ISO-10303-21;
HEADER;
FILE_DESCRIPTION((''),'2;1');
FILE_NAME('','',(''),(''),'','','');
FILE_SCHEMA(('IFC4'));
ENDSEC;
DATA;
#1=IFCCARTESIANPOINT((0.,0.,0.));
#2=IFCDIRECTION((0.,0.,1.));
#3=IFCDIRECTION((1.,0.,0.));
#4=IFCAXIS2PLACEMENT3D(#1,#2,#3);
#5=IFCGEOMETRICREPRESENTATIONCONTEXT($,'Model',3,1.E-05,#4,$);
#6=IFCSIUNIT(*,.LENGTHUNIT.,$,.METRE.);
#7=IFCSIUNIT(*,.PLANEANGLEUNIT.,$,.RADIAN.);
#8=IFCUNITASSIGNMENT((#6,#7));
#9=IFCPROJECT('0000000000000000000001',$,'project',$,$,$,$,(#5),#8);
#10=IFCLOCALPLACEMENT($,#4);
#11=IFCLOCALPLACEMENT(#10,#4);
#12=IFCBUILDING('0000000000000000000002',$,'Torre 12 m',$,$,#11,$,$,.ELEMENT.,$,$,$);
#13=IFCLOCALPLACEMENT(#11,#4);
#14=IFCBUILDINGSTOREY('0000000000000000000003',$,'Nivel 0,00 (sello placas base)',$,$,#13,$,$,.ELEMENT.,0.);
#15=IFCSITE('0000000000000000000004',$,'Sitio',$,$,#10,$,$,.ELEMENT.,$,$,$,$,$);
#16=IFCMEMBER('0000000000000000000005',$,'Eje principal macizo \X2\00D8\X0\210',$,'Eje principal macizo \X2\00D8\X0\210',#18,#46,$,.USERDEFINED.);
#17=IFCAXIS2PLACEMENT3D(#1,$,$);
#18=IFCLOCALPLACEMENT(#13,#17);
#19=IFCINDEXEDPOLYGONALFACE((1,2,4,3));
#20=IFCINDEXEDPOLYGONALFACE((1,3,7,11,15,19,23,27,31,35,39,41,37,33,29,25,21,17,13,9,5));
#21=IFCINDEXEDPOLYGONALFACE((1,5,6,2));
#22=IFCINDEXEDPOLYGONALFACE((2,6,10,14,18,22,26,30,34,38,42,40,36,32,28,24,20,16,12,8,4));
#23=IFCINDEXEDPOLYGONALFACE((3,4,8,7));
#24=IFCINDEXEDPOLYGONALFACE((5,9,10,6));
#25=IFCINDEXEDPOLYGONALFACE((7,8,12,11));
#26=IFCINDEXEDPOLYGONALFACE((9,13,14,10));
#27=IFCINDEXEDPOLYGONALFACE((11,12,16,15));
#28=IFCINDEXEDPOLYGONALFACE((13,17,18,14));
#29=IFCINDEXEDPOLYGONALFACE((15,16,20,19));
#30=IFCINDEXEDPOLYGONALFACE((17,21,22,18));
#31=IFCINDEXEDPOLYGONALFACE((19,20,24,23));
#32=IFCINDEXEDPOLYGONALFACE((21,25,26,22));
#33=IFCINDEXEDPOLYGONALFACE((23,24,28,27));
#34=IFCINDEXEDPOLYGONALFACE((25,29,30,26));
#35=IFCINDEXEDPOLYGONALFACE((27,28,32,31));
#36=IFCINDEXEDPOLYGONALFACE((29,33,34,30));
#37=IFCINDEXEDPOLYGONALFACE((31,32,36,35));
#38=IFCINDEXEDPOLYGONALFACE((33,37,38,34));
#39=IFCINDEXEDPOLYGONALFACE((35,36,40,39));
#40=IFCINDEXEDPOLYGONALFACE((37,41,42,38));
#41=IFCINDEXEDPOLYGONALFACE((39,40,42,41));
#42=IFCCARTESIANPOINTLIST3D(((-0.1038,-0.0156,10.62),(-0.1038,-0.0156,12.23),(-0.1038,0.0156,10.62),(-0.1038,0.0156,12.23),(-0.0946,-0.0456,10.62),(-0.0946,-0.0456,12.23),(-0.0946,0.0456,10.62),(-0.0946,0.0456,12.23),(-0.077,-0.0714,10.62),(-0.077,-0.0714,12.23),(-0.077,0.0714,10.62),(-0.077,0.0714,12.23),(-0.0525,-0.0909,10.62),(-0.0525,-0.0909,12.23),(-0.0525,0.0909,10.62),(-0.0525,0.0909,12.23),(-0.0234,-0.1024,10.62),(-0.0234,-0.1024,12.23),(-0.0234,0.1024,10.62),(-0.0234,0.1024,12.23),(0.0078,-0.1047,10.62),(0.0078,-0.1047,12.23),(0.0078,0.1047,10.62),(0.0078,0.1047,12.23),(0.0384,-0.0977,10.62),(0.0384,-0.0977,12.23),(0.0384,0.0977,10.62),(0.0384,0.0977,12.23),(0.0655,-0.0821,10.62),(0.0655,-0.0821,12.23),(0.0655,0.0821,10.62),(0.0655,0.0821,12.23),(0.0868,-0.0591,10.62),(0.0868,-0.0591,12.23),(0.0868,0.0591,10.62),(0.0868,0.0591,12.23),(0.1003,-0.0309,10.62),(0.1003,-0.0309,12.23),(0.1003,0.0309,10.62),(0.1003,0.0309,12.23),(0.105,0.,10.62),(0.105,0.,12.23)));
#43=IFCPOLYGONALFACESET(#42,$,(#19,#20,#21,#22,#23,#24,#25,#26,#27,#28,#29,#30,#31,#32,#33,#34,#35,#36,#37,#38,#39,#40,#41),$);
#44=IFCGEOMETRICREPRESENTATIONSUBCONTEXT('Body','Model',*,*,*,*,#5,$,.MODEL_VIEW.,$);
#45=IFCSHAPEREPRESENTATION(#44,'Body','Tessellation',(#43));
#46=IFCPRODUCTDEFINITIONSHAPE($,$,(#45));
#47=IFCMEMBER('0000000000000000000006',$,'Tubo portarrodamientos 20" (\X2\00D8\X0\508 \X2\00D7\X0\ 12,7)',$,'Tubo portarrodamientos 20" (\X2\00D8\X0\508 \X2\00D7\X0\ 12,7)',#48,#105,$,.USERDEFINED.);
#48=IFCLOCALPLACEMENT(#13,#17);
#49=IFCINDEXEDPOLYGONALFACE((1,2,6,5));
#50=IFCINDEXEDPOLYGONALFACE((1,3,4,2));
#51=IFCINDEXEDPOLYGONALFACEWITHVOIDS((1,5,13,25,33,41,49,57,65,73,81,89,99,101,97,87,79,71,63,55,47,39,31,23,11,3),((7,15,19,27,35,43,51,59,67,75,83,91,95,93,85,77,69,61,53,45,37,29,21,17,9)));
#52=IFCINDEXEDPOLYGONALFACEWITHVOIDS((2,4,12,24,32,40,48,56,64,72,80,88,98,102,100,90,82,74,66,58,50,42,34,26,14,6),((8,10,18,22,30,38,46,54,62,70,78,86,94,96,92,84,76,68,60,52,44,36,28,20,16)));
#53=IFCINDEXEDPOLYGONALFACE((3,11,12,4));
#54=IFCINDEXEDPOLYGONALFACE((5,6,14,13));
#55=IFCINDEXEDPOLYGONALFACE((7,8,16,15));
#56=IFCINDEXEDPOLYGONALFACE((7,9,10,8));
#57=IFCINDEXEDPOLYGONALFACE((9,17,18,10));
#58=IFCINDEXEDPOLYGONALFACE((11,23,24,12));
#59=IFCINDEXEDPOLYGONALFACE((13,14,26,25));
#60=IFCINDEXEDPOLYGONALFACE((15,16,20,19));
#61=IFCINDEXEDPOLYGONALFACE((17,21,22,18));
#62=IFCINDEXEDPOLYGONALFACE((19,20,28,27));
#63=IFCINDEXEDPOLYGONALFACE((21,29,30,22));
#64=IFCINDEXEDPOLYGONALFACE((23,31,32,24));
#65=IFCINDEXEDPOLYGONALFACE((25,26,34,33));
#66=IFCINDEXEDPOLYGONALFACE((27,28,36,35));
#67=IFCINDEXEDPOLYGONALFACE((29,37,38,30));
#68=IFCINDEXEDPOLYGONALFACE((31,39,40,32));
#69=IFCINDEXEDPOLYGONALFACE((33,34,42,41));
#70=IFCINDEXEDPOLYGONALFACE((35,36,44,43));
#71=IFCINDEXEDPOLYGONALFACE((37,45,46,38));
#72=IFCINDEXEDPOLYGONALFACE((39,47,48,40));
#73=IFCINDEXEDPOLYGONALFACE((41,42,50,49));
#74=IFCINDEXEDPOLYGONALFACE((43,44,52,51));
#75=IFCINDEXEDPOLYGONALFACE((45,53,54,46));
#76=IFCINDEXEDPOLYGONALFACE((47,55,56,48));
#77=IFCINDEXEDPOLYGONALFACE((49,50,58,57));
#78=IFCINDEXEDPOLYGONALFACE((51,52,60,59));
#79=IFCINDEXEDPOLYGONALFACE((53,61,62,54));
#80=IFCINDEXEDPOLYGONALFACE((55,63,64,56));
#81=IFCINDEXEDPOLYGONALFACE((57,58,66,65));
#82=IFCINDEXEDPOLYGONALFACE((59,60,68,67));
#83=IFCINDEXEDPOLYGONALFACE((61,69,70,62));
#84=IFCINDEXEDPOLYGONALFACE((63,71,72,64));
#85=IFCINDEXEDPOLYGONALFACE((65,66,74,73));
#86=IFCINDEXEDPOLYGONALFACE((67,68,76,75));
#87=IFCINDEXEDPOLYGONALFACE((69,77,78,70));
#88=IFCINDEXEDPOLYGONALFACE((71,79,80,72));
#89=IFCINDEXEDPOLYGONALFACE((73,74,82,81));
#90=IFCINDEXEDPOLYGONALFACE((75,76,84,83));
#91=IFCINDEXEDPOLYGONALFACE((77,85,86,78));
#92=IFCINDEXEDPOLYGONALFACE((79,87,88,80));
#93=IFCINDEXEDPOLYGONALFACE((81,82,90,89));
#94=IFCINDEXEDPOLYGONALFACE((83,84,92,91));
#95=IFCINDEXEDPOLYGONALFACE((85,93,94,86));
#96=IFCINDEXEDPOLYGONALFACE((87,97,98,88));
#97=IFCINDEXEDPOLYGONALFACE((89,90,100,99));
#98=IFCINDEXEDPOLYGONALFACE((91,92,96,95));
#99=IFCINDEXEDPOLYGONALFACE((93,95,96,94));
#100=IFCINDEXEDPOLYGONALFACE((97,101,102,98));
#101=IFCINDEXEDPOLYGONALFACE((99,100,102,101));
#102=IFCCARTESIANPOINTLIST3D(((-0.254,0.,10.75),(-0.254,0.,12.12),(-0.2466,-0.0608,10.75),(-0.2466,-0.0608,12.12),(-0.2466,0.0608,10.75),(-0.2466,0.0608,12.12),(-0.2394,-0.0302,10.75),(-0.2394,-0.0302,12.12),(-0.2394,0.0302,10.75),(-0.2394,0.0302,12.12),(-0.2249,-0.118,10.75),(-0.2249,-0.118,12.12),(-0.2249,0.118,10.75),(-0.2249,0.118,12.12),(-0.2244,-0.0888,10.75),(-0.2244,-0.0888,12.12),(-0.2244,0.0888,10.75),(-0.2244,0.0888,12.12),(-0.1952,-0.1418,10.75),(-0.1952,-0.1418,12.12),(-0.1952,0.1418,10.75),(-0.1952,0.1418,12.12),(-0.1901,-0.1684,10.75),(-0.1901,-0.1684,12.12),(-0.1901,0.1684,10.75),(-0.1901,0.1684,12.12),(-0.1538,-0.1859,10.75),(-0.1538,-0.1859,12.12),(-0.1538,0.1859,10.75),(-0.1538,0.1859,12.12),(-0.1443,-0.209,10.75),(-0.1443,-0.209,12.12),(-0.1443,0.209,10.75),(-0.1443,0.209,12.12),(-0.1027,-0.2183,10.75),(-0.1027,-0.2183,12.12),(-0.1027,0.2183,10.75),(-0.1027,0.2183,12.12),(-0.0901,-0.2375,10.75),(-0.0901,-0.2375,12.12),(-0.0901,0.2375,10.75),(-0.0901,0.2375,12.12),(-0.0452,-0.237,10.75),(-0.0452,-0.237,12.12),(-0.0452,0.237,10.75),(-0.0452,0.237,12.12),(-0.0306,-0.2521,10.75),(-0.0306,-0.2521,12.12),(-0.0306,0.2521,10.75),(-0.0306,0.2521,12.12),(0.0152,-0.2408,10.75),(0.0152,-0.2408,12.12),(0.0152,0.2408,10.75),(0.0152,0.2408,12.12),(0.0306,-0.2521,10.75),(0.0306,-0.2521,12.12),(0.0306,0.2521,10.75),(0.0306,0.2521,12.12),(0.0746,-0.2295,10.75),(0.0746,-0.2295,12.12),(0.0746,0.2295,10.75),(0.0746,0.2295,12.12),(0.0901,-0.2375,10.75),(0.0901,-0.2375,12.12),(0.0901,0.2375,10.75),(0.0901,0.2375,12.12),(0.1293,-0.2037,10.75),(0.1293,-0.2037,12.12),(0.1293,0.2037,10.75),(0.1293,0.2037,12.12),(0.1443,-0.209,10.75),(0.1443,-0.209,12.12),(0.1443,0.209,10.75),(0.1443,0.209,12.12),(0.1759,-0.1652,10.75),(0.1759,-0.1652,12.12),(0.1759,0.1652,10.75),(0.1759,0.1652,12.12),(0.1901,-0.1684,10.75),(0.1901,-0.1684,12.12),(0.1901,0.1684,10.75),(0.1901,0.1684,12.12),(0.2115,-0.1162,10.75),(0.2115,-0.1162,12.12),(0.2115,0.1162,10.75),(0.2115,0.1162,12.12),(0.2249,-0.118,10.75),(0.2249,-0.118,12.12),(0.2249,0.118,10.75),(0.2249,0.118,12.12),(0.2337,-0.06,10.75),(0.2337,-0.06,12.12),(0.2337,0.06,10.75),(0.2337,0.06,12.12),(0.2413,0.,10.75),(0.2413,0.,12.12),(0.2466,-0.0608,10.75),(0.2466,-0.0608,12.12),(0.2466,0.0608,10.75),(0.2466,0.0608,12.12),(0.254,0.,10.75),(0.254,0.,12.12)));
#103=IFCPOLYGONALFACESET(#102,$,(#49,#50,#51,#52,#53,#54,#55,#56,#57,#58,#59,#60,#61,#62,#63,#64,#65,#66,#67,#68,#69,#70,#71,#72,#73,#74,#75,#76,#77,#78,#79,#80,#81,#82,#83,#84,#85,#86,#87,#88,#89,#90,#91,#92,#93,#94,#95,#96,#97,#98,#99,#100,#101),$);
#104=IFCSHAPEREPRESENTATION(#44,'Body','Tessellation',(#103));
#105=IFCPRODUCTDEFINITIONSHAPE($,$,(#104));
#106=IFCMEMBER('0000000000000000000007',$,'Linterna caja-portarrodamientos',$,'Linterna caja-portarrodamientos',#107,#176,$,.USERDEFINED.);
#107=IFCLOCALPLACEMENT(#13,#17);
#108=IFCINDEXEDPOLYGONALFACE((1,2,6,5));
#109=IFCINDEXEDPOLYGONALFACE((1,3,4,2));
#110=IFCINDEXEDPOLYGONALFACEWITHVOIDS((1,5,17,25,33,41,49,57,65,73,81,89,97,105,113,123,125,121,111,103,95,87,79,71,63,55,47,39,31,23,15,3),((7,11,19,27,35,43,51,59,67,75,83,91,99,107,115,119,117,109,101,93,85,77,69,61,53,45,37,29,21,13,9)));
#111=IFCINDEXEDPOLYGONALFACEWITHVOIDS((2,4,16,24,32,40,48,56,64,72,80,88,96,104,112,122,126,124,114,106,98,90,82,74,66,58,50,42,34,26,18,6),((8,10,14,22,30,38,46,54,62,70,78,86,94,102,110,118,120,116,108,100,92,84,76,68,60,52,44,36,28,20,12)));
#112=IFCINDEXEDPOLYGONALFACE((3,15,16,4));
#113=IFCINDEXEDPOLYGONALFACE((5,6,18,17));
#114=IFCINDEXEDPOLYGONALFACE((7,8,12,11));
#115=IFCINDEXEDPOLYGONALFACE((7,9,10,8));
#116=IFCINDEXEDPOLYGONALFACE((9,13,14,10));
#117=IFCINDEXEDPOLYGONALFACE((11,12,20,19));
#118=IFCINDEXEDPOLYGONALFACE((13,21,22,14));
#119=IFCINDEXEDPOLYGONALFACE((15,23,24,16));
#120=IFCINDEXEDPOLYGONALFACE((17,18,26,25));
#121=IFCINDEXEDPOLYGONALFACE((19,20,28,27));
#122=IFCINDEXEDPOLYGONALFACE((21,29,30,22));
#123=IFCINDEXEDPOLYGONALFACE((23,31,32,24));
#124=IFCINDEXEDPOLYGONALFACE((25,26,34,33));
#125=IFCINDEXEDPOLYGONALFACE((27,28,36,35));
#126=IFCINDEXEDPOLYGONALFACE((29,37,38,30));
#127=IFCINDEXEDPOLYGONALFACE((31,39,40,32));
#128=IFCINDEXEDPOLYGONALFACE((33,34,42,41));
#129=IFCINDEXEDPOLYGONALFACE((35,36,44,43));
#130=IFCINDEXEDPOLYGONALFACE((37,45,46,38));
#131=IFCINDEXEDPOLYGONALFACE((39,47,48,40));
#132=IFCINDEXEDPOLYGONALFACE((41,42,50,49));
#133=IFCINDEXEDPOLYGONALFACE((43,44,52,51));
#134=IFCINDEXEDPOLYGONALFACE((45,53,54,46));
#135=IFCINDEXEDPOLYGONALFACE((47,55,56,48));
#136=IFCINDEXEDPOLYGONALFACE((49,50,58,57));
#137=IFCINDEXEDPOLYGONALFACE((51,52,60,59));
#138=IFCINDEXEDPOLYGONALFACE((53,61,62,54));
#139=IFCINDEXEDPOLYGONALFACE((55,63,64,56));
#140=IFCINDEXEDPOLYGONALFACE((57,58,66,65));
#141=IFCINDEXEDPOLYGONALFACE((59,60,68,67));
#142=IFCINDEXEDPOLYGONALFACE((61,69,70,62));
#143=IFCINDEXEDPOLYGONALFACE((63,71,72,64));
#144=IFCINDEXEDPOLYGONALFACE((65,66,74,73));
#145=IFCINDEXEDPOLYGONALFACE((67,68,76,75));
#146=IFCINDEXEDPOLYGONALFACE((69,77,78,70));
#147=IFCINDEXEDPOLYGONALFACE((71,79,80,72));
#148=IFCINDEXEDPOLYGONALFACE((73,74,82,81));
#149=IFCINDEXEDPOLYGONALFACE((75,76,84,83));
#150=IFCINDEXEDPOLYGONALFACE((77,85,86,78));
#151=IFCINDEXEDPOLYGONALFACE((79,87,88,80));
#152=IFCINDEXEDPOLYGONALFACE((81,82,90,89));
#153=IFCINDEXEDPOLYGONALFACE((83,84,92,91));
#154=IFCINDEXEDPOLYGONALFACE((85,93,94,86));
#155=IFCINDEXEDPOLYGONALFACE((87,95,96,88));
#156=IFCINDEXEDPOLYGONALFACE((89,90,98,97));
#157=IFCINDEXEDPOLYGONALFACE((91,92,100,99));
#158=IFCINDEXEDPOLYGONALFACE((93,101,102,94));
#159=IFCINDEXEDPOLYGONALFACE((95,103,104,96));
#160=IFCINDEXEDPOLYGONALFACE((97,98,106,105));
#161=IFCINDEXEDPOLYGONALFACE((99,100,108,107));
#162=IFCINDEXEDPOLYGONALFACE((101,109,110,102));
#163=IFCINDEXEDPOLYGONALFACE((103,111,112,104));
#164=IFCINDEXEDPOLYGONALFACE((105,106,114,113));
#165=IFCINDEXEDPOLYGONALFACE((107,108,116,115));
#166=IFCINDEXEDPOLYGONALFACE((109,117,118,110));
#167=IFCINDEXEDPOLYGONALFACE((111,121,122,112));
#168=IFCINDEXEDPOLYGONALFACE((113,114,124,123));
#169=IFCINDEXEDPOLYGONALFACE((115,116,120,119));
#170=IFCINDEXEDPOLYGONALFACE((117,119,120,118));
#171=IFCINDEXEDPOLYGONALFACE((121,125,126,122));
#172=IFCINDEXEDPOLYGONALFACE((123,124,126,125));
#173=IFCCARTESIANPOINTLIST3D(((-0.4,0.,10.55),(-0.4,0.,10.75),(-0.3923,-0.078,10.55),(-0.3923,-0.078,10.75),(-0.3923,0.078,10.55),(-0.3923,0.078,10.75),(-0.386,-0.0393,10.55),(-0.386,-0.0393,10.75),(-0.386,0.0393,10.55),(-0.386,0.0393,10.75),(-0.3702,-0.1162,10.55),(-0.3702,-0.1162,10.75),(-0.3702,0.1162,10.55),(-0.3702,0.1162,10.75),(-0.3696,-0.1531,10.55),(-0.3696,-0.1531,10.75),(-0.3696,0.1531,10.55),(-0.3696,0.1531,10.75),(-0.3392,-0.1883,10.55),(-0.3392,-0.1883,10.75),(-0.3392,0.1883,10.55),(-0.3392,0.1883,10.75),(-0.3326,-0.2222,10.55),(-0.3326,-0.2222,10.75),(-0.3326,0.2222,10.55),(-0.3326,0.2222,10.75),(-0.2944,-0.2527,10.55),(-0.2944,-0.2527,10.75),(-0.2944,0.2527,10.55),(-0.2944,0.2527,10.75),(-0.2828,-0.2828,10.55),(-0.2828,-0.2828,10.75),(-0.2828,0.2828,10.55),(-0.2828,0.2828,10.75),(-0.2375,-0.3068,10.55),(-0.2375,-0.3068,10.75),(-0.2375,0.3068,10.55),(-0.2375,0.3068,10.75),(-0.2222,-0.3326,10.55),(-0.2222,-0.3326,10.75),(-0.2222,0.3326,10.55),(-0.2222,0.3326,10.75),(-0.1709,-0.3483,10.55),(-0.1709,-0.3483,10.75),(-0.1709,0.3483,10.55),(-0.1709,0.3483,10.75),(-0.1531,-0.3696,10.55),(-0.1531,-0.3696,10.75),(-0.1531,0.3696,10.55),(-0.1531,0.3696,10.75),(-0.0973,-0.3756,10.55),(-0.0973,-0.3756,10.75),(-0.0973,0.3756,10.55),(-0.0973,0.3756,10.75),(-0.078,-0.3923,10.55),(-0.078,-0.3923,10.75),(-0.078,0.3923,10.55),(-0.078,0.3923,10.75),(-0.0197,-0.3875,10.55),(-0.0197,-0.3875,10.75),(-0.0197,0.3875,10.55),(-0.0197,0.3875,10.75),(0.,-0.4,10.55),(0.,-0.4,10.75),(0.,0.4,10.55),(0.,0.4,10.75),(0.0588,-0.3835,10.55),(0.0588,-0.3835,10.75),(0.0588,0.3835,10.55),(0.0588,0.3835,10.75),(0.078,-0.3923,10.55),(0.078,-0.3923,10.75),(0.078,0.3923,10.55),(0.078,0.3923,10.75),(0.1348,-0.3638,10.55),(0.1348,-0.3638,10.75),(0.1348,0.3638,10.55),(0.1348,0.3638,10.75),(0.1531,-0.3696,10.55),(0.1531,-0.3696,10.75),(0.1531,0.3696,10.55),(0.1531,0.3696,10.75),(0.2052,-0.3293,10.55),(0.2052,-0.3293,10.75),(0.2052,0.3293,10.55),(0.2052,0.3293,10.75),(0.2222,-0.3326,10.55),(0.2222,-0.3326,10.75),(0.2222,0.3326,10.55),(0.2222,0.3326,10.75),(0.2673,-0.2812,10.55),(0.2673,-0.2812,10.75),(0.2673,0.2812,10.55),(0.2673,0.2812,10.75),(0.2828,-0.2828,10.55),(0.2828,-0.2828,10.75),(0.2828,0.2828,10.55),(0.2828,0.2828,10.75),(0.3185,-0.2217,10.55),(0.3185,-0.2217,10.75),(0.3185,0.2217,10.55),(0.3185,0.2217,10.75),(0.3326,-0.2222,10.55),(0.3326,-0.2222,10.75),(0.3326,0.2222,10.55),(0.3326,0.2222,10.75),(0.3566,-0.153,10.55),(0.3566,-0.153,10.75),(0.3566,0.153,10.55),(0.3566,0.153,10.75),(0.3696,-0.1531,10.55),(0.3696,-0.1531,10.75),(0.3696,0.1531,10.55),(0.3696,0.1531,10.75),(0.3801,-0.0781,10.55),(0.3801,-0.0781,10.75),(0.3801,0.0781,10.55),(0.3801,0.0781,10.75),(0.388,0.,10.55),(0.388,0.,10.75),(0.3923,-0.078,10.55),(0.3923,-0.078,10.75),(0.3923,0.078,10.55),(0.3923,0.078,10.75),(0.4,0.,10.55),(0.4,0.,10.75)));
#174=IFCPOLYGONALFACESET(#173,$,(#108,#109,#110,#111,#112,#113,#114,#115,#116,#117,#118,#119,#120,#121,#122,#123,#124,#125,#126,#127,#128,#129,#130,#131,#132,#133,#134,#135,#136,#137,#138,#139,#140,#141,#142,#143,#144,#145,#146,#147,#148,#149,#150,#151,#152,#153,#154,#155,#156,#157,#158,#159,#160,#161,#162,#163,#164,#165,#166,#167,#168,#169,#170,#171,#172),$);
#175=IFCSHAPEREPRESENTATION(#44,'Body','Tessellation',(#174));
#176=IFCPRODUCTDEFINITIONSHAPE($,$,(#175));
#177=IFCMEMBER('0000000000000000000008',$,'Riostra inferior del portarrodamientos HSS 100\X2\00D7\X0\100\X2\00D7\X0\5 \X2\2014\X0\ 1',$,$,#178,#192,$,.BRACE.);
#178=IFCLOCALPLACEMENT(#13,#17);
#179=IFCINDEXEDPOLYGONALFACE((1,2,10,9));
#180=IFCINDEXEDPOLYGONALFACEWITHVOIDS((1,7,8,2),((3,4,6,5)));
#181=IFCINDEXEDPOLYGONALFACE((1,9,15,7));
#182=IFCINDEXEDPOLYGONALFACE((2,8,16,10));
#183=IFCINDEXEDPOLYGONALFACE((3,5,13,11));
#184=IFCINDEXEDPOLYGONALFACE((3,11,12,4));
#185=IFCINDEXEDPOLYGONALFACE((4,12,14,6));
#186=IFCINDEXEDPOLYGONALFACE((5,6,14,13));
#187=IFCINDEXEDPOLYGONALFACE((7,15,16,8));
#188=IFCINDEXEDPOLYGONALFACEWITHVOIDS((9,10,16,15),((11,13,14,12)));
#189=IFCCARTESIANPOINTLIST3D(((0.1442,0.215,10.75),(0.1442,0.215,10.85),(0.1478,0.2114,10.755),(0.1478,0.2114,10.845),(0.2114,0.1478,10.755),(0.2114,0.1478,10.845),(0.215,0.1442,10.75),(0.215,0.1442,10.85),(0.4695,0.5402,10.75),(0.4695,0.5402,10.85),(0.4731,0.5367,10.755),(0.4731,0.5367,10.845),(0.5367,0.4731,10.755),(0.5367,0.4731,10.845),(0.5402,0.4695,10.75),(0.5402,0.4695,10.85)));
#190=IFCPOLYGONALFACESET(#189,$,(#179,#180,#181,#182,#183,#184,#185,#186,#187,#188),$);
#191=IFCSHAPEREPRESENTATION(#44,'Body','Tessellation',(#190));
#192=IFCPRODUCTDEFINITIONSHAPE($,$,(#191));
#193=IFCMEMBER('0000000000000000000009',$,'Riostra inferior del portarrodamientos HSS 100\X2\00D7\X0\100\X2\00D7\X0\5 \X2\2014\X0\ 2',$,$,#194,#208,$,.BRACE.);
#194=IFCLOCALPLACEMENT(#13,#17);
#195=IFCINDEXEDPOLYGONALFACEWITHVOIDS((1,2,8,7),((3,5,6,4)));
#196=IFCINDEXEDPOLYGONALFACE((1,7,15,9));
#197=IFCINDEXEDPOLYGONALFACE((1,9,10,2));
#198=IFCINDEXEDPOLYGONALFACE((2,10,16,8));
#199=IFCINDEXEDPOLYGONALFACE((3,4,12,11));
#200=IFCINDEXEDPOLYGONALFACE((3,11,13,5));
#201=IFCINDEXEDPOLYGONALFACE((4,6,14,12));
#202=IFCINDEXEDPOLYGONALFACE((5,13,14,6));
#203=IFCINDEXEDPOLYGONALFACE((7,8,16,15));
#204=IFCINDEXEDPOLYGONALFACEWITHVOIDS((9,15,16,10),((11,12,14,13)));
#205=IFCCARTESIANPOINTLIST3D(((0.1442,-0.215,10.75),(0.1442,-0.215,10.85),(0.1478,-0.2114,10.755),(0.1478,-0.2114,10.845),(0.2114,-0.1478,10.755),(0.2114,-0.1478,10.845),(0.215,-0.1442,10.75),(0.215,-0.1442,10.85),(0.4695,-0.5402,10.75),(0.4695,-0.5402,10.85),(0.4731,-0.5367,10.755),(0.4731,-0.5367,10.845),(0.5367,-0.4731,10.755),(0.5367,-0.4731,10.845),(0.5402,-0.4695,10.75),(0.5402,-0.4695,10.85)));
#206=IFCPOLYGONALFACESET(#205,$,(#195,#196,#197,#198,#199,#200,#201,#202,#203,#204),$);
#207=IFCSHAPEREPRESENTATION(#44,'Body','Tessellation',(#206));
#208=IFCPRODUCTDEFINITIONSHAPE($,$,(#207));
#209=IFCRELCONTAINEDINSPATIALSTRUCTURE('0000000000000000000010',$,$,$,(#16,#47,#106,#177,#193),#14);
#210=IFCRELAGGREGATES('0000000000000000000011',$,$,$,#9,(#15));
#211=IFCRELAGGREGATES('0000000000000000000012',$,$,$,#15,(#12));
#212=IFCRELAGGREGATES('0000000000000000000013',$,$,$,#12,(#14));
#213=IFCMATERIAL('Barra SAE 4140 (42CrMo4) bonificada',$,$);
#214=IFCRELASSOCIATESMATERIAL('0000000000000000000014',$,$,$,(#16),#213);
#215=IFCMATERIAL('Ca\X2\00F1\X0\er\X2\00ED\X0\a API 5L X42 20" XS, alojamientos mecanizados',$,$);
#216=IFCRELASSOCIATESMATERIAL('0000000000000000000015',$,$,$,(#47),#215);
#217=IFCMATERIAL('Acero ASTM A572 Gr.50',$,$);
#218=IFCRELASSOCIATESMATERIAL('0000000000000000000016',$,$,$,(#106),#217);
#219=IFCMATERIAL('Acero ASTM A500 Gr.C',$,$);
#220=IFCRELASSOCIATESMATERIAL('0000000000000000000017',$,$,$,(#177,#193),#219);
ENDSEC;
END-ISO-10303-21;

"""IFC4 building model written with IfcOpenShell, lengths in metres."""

from ifc_helpers import new_model, si_unit, frame, origin, origin_with_axes, origin_2d, place, context, subcontext, project, spatial, hollow_rectangle, circle, hollow_circle, extrude, material, element, save


model = new_model("IFC4")

# Units and contexts
model_context = context("Model", 3, precision=1e-05, world=origin_with_axes())
body_context = subcontext(model_context, "Body", "Model", "MODEL_VIEW")
ifc_project = project(units=[si_unit("LENGTHUNIT", "METRE"), si_unit("PLANEANGLEUNIT", "RADIAN")], contexts=[model_context])

# Site, building, storey
site_placement = place(None, origin_with_axes())
site = spatial("IfcSite", under=ifc_project, at=site_placement, Name="Sitio", CompositionType="ELEMENT")
building_placement = place(site_placement, origin_with_axes())
building = spatial("IfcBuilding", under=site, at=building_placement, Name="Torre 12 m", CompositionType="ELEMENT")
storey_placement = place(building_placement, origin_with_axes())
storey = spatial("IfcBuildingStorey", under=building, at=storey_placement, Name="Nivel 0,00 (sello placas base)", CompositionType="ELEMENT", Elevation=0.0)

# Members
ifc_material_1 = material(Name="Barra SAE 4140 (42CrMo4) bonificada")
member_1_placement = place(storey_placement, frame((0.0, 0.0, 10.62), z_axis=(0.0, 0.0, 1.0), x_axis=(1.0, 0.0, 0.0)))
element("IfcMember", 1, at=member_1_placement, inside=storey, material=ifc_material_1, Name="Eje principal macizo Ø210", ObjectType="Eje principal macizo Ø210", PredefinedType="USERDEFINED", context=body_context, shape_type="SweptSolid", body=[
    extrude(circle(Radius=0.105, at=origin_2d()), origin(), (0.0, 0.0, 1.0), 1.61),
])
ifc_material_2 = material(Name="Cañería API 5L X42 20\" XS, alojamientos mecanizados")
member_2_placement = place(storey_placement, frame((0.0, 0.0, 10.75), z_axis=(0.0, 0.0, 1.0), x_axis=(1.0, 0.0, 0.0)))
element("IfcMember", 2, at=member_2_placement, inside=storey, material=ifc_material_2, Name="Tubo portarrodamientos 20\" (Ø508 × 12,7)", ObjectType="Tubo portarrodamientos 20\" (Ø508 × 12,7)", PredefinedType="USERDEFINED", context=body_context, shape_type="SweptSolid", body=[
    extrude(hollow_circle(Radius=0.254, WallThickness=0.0127, at=origin_2d()), origin(), (0.0, 0.0, 1.0), 1.37),
])
ifc_material_3 = material(Name="Acero ASTM A572 Gr.50")
member_3_placement = place(storey_placement, frame((0.0, 0.0, 10.55), z_axis=(0.0, 0.0, 1.0), x_axis=(1.0, 0.0, 0.0)))
element("IfcMember", 3, at=member_3_placement, inside=storey, material=ifc_material_3, Name="Linterna caja-portarrodamientos", ObjectType="Linterna caja-portarrodamientos", PredefinedType="USERDEFINED", context=body_context, shape_type="SweptSolid", body=[
    extrude(hollow_circle(Radius=0.4, WallThickness=0.012, at=origin_2d()), origin(), (0.0, 0.0, 1.0), 0.2),
])
ifc_material_4 = material(Name="Acero ASTM A500 Gr.C")
for number, where, z_axis, x_axis, name in (
    (4, (0.1796, 0.1796, 10.8), (0.707107, 0.707107, 0.0), (0.0, 0.0, 1.0), "Riostra inferior del portarrodamientos HSS 100×100×5 — 1"),
    (5, (0.1796, -0.1796, 10.8), (0.707107, -0.707107, 0.0), (0.0, 0.0, 1.0), "Riostra inferior del portarrodamientos HSS 100×100×5 — 2"),
):
    element("IfcMember", number, at=place(storey_placement, frame(where, z_axis=z_axis, x_axis=x_axis)), inside=storey, material=ifc_material_4, Name=name, PredefinedType="BRACE", context=body_context, shape_type="SweptSolid", body=[
        extrude(hollow_rectangle(XDim=0.1, YDim=0.1, WallThickness=0.005, at=origin_2d()), origin(), (0.0, 0.0, 1.0), 0.46),
    ])

save(model, "model.ifc")
